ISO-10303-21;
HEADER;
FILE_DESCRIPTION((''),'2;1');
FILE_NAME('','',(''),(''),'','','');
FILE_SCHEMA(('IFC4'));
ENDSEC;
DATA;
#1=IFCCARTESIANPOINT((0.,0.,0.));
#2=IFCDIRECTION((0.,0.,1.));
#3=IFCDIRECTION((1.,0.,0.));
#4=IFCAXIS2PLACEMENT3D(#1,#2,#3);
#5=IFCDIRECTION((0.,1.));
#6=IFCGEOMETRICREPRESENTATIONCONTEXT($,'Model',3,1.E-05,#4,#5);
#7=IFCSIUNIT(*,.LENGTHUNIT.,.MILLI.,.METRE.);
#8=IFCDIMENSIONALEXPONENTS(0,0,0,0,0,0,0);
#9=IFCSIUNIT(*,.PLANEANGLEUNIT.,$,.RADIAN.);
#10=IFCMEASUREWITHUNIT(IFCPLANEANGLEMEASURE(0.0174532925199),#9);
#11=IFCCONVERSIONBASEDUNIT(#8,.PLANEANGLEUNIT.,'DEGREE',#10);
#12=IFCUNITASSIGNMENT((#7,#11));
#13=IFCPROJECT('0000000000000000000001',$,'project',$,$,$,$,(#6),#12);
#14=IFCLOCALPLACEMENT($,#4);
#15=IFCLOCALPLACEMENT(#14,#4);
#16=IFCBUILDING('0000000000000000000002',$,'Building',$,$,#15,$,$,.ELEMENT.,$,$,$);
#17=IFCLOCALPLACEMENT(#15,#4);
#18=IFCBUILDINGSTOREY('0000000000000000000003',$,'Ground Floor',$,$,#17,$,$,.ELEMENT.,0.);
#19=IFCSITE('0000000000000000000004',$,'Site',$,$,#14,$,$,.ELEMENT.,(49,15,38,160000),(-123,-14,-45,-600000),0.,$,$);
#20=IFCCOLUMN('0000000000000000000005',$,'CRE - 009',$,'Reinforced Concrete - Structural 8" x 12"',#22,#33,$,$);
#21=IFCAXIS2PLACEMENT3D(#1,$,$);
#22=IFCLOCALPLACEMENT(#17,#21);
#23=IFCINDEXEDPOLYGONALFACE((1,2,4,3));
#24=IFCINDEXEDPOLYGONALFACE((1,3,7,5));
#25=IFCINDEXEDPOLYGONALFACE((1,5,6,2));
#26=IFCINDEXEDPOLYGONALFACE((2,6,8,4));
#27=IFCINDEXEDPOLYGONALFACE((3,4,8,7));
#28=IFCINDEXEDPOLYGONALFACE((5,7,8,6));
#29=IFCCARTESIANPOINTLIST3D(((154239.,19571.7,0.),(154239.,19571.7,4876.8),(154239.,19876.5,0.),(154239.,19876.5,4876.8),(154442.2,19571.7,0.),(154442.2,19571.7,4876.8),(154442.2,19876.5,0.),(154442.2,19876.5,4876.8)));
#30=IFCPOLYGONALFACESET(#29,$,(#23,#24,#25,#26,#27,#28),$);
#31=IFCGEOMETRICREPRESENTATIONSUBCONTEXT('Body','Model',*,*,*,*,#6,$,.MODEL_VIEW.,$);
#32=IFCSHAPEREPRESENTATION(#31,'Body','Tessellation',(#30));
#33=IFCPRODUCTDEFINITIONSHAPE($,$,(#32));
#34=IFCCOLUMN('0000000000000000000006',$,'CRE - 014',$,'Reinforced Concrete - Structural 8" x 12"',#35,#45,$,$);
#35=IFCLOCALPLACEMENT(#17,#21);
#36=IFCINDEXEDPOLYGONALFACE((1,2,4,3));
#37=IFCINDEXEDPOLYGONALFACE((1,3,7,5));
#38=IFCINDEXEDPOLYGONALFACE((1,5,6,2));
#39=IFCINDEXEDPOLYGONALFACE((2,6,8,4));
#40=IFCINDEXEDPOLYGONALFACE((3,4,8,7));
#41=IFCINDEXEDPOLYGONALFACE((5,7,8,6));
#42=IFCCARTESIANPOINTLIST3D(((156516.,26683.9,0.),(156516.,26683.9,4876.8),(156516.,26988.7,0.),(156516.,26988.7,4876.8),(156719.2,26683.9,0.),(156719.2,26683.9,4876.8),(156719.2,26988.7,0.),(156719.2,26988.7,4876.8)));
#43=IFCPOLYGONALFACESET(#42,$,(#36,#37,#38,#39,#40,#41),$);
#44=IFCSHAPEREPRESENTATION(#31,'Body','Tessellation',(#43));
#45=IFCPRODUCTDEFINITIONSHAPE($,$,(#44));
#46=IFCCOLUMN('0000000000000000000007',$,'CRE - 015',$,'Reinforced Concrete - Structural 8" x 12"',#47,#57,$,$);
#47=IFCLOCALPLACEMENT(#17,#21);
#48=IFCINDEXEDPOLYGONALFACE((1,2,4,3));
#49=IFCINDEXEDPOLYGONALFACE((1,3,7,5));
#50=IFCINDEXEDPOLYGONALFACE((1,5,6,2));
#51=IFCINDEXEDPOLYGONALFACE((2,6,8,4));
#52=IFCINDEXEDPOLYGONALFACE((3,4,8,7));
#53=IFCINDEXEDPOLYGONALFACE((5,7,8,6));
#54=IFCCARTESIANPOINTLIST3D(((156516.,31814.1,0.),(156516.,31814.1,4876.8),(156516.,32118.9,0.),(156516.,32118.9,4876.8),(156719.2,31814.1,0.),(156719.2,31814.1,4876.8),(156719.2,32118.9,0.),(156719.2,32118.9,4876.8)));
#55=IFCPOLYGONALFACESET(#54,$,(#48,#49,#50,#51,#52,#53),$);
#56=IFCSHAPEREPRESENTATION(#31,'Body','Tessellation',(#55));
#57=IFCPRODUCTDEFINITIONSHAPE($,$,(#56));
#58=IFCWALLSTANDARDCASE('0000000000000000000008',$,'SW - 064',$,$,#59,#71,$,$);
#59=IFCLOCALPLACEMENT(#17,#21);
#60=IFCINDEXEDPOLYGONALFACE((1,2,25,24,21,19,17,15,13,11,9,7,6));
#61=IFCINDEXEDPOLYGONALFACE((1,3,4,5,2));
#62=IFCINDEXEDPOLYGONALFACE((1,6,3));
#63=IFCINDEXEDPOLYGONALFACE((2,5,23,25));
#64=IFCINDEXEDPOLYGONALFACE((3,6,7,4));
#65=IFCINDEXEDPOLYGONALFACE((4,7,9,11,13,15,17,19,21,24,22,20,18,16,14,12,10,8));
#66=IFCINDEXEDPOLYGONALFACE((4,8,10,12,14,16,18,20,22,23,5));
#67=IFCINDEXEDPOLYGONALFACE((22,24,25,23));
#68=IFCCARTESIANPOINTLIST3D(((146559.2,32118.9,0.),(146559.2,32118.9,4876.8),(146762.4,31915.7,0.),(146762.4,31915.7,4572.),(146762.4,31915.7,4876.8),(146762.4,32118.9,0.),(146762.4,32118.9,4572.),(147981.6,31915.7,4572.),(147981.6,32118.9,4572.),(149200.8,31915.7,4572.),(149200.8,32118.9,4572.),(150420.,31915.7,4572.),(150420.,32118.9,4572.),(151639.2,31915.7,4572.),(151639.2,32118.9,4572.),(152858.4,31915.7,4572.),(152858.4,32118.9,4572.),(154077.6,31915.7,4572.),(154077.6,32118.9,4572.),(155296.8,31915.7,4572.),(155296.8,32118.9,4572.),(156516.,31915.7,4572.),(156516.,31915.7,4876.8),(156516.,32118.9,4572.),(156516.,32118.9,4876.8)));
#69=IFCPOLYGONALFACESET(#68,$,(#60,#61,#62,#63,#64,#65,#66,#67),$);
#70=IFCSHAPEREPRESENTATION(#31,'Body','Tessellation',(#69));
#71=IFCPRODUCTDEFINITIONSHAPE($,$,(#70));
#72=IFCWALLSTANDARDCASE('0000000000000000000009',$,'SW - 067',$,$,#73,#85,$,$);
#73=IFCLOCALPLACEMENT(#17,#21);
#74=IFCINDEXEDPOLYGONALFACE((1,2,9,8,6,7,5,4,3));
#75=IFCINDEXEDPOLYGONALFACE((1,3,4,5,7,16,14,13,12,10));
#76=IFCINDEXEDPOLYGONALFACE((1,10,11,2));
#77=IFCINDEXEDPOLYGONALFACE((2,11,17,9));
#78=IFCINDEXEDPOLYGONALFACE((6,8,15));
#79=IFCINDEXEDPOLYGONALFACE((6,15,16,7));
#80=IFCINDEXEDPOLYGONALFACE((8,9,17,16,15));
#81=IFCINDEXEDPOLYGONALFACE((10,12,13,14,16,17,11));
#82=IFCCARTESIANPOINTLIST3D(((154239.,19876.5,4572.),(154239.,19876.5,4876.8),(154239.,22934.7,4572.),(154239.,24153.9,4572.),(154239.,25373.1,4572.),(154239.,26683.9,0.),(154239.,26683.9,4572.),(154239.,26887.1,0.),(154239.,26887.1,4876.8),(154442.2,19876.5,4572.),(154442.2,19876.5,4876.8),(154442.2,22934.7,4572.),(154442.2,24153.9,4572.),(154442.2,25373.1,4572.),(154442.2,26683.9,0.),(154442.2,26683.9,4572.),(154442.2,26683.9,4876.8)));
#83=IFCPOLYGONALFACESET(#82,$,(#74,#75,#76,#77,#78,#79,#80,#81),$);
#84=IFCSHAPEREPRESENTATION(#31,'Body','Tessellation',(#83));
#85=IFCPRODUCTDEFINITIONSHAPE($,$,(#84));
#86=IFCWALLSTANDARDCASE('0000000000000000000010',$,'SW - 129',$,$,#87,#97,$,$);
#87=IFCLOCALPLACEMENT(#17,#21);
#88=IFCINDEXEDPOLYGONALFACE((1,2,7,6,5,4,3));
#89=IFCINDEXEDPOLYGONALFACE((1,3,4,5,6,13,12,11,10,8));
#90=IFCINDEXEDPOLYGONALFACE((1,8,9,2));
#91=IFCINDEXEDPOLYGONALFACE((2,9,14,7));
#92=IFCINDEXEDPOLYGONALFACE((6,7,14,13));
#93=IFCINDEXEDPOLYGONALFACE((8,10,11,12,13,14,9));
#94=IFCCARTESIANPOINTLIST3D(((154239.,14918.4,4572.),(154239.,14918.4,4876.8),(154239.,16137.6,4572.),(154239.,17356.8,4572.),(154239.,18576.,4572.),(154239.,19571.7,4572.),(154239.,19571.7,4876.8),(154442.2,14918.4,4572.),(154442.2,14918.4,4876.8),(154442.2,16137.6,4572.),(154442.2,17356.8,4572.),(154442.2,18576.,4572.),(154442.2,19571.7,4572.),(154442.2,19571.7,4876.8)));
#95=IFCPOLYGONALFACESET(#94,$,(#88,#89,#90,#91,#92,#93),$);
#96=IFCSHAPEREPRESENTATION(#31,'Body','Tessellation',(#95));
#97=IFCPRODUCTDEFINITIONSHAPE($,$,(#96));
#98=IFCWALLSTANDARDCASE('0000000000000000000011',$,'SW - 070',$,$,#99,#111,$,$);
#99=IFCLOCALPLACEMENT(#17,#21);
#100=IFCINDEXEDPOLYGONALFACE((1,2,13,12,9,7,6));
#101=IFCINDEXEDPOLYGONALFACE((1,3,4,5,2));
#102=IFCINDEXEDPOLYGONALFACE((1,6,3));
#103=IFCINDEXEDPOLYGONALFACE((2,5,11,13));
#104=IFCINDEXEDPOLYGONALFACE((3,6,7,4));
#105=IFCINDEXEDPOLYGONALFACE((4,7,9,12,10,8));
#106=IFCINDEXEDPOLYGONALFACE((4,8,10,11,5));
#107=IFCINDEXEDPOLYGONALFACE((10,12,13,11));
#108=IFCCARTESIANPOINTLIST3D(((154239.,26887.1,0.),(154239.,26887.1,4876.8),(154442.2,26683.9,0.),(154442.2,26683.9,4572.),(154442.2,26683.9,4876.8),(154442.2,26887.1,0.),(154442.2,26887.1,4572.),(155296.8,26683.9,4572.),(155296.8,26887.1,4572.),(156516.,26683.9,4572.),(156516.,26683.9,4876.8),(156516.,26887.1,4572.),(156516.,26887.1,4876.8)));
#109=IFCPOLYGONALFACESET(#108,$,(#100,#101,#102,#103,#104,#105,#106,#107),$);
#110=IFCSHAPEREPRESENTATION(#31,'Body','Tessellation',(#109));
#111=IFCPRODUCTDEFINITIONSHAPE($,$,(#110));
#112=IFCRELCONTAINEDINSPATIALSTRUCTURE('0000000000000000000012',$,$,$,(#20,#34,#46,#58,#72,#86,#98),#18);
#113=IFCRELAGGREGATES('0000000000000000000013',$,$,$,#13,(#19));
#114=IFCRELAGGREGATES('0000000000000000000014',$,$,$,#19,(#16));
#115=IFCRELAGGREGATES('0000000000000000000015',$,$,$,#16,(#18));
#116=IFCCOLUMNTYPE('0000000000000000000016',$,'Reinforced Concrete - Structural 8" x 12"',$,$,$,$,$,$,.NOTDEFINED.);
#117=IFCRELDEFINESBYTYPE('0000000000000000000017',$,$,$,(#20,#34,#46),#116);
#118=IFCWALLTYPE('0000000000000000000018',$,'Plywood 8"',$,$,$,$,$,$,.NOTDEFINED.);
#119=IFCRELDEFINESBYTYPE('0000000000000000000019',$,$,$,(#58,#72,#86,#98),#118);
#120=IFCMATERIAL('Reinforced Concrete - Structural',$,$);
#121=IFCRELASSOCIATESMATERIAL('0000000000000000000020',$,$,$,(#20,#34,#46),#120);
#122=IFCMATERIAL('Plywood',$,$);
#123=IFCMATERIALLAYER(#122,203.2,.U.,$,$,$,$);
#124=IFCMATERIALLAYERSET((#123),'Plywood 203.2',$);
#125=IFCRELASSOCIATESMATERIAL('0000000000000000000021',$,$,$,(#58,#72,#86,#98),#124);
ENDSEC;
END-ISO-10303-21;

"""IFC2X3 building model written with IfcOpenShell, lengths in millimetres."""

from ifc_helpers import new_model, entity, si_unit, converted_unit, direction, frame, origin_with_axes, origin_2d_with_axis, place, context, subcontext, project, spatial, polyline, rectangle, outline, extrude, material, layer, layer_set, layer_usage, type_object, element, save


model = new_model("IFC2X3")

# Units and contexts
model_context = context("Model", 3, precision=1e-05, world=origin_with_axes(), true_north=direction((0.0, 1.0)))
body_context = subcontext(model_context, "Body", "Model", "MODEL_VIEW")
ifc_project = project(units=[si_unit("LENGTHUNIT", "METRE", prefix="MILLI"), converted_unit("PLANEANGLEUNIT", "DEGREE", entity("IfcPlaneAngleMeasure", 0.0174532925199), si_unit("PLANEANGLEUNIT", "RADIAN"), dimensions=[0, 0, 0, 0, 0, 0, 0])], contexts=[model_context])

# Site, building, storey
site_placement = place(None, origin_with_axes())
site = spatial("IfcSite", under=ifc_project, at=site_placement, Name="Site", CompositionType="ELEMENT", RefLatitude=(49, 15, 38, 160000), RefLongitude=(-123, -14, -45, -600000), RefElevation=0.0)
building_placement = place(site_placement, origin_with_axes())
building = spatial("IfcBuilding", under=site, at=building_placement, Name="Building", CompositionType="ELEMENT")
storey_placement = place(building_placement, origin_with_axes())
storey = spatial("IfcBuildingStorey", under=building, at=storey_placement, Name="Ground Floor", CompositionType="ELEMENT", Elevation=0.0)

# Columns
ifc_material_1 = material(Name="Reinforced Concrete - Structural")
column_type = type_object("IfcColumnType", Name="Reinforced Concrete - Structural 8\" x 12\"", PredefinedType="NOTDEFINED")
for number, where, z_axis, x_axis, name in (
    (1, (154340.6, 19724.1, 0.0), (0.0, 0.0, 1.0), (1.0, 0.0, 0.0), "CRE - 009"),
    (2, (156617.6, 26836.3, 0.0), (0.0, 0.0, 1.0), (1.0, 0.0, 0.0), "CRE - 014"),
    (3, (156617.6, 31966.5, 0.0), (0.0, 0.0, 1.0), (1.0, 0.0, 0.0), "CRE - 015"),
):
    element("IfcColumn", number, at=place(storey_placement, frame(where, z_axis=z_axis, x_axis=x_axis)), inside=storey, type_object=column_type, material=ifc_material_1, Name=name, ObjectType="Reinforced Concrete - Structural 8\" x 12\"", context=body_context, shape_type="SweptSolid", body=[
        extrude(rectangle(XDim=203.2, YDim=304.8, at=origin_2d_with_axis()), origin_with_axes(), (0.0, 0.0, 1.0), 4876.8),
    ])

# Walls, openings
ifc_material_2 = material(Name="Plywood")
ifc_layer = layer(ifc_material_2, 203.2, ventilated="UNKNOWN")
ifc_layer_set = layer_set([ifc_layer], Name="Plywood 203.2")
ifc_layer_usage_1 = layer_usage(ifc_layer_set, "AXIS2", "NEGATIVE", 0.0)
wall_type = type_object("IfcWallType", Name="Plywood 8\"", PredefinedType="NOTDEFINED")
wall_1_placement = place(storey_placement, frame((156516.0, 31915.7, 0.0), z_axis=(0.0, 0.0, 1.0), x_axis=(-1.0, 0.0, 0.0)))
wall_1 = element("IfcWallStandardCase", 4, at=wall_1_placement, inside=storey, type_object=wall_type, material=ifc_layer_usage_1, Name="SW - 064", context=body_context, shape_type="SweptSolid", body=[
    extrude(outline(polyline([(0.0, -203.2), (9956.8, -203.2), (9753.6, 0.0), (0.0, 0.0), (0.0, -203.2)])), origin_with_axes(), (0.0, 0.0, 1.0), 4876.8),
])
opening_1_placement = place(wall_1_placement, frame((9144.0, 0.0, 0.0), z_axis=(0.0, 0.0, 1.0), x_axis=(1.0, 0.0, 0.0)))
element("IfcOpeningElement", 5, at=opening_1_placement, cuts=wall_1, context=body_context, shape_type="SweptSolid", body=[
    extrude(rectangle(XDim=1219.2, YDim=4572.0, at=origin_2d_with_axis()), frame((0.0, 203.2, 2286.0), z_axis=(0.0, -1.0, 0.0), x_axis=(-1.0, 0.0, 0.0)), (0.0, 0.0, 1.0), 609.6),
])
opening_2_placement = place(wall_1_placement, frame((609.6, 0.0, 0.0), z_axis=(0.0, 0.0, 1.0), x_axis=(1.0, 0.0, 0.0)))
element("IfcOpeningElement", 6, at=opening_2_placement, cuts=wall_1, context=body_context, shape_type="SweptSolid", body=[
    extrude(rectangle(XDim=1219.2, YDim=4572.0, at=origin_2d_with_axis()), frame((0.0, 203.2, 2286.0), z_axis=(0.0, -1.0, 0.0), x_axis=(-1.0, 0.0, 0.0)), (0.0, 0.0, 1.0), 609.6),
])
opening_3_placement = place(wall_1_placement, frame((1828.8, 0.0, 0.0), z_axis=(0.0, 0.0, 1.0), x_axis=(1.0, 0.0, 0.0)))
element("IfcOpeningElement", 7, at=opening_3_placement, cuts=wall_1, context=body_context, shape_type="SweptSolid", body=[
    extrude(rectangle(XDim=1219.2, YDim=4572.0, at=origin_2d_with_axis()), frame((0.0, 203.2, 2286.0), z_axis=(0.0, 1.0, 0.0), x_axis=(1.0, 0.0, 0.0)), (0.0, 0.0, -1.0), 609.6),
])
opening_4_placement = place(wall_1_placement, frame((3048.0, 0.0, 0.0), z_axis=(0.0, 0.0, 1.0), x_axis=(1.0, 0.0, 0.0)))
element("IfcOpeningElement", 8, at=opening_4_placement, cuts=wall_1, context=body_context, shape_type="SweptSolid", body=[
    extrude(rectangle(XDim=1219.2, YDim=4572.0, at=origin_2d_with_axis()), frame((0.0, 203.2, 2286.0), z_axis=(0.0, 1.0, 0.0), x_axis=(1.0, 0.0, 0.0)), (0.0, 0.0, -1.0), 609.6),
])
opening_5_placement = place(wall_1_placement, frame((4267.2, 0.0, 0.0), z_axis=(0.0, 0.0, 1.0), x_axis=(1.0, 0.0, 0.0)))
element("IfcOpeningElement", 9, at=opening_5_placement, cuts=wall_1, context=body_context, shape_type="SweptSolid", body=[
    extrude(rectangle(XDim=1219.2, YDim=4572.0, at=origin_2d_with_axis()), frame((0.0, 203.2, 2286.0), z_axis=(0.0, -1.0, 0.0), x_axis=(-1.0, 0.0, 0.0)), (0.0, 0.0, 1.0), 609.6),
])
opening_6_placement = place(wall_1_placement, frame((5486.4, 0.0, 0.0), z_axis=(0.0, 0.0, 1.0), x_axis=(1.0, 0.0, 0.0)))
element("IfcOpeningElement", 10, at=opening_6_placement, cuts=wall_1, context=body_context, shape_type="SweptSolid", body=[
    extrude(rectangle(XDim=1219.2, YDim=4572.0, at=origin_2d_with_axis()), frame((0.0, 203.2, 2286.0), z_axis=(0.0, 1.0, 0.0), x_axis=(1.0, 0.0, 0.0)), (0.0, 0.0, -1.0), 609.6),
])
opening_7_placement = place(wall_1_placement, frame((6705.6, 0.0, 0.0), z_axis=(0.0, 0.0, 1.0), x_axis=(1.0, 0.0, 0.0)))
element("IfcOpeningElement", 11, at=opening_7_placement, cuts=wall_1, context=body_context, shape_type="SweptSolid", body=[
    extrude(rectangle(XDim=1219.2, YDim=4572.0, at=origin_2d_with_axis()), frame((0.0, 203.2, 2286.0), z_axis=(0.0, -1.0, 0.0), x_axis=(-1.0, 0.0, 0.0)), (0.0, 0.0, 1.0), 609.6),
])
opening_8_placement = place(wall_1_placement, frame((7924.8, 0.0, 0.0), z_axis=(0.0, 0.0, 1.0), x_axis=(1.0, 0.0, 0.0)))
element("IfcOpeningElement", 12, at=opening_8_placement, cuts=wall_1, context=body_context, shape_type="SweptSolid", body=[
    extrude(rectangle(XDim=1219.2, YDim=4572.0, at=origin_2d_with_axis()), frame((0.0, 203.2, 2286.0), z_axis=(0.0, 1.0, 0.0), x_axis=(1.0, 0.0, 0.0)), (0.0, 0.0, -1.0), 609.6),
])
ifc_layer_usage_2 = layer_usage(ifc_layer_set, "AXIS2", "POSITIVE", 0.0)
wall_2_placement = place(storey_placement, frame((154239.0, 26887.1, 0.0), z_axis=(0.0, 0.0, 1.0), x_axis=(0.0, -1.0, 0.0)))
wall_2 = element("IfcWallStandardCase", 13, at=wall_2_placement, inside=storey, type_object=wall_type, material=ifc_layer_usage_2, Name="SW - 067", context=body_context, shape_type="SweptSolid", body=[
    extrude(outline(polyline([(0.0, 0.0), (7010.6, 0.0), (7010.6, 203.2), (203.2, 203.2), (0.0, 0.0)])), origin_with_axes(), (0.0, 0.0, 1.0), 4876.8),
])
opening_9_placement = place(wall_2_placement, frame((858.6, 0.0, 0.0), z_axis=(0.0, 0.0, 1.0), x_axis=(1.0, 0.0, 0.0)))
element("IfcOpeningElement", 14, at=opening_9_placement, cuts=wall_2, context=body_context, shape_type="SweptSolid", body=[
    extrude(rectangle(XDim=1310.8, YDim=4572.0, at=origin_2d_with_axis()), frame((0.0, -203.2, 2286.0), z_axis=(0.0, -1.0, 0.0), x_axis=(-1.0, 0.0, 0.0)), (0.0, 0.0, -1.0), 609.6),
])
opening_10_placement = place(wall_2_placement, frame((2123.6, 0.0, 0.0), z_axis=(0.0, 0.0, 1.0), x_axis=(1.0, 0.0, 0.0)))
element("IfcOpeningElement", 15, at=opening_10_placement, cuts=wall_2, context=body_context, shape_type="SweptSolid", body=[
    extrude(rectangle(XDim=1219.2, YDim=4572.0, at=origin_2d_with_axis()), frame((0.0, -203.2, 2286.0), z_axis=(0.0, 1.0, 0.0), x_axis=(1.0, 0.0, 0.0)), (0.0, 0.0, 1.0), 609.6),
])
opening_11_placement = place(wall_2_placement, frame((3342.8, 0.0, 0.0), z_axis=(0.0, 0.0, 1.0), x_axis=(1.0, 0.0, 0.0)))
element("IfcOpeningElement", 16, at=opening_11_placement, cuts=wall_2, context=body_context, shape_type="SweptSolid", body=[
    extrude(rectangle(XDim=1219.2, YDim=4572.0, at=origin_2d_with_axis()), frame((0.0, -203.2, 2286.0), z_axis=(0.0, -1.0, 0.0), x_axis=(-1.0, 0.0, 0.0)), (0.0, 0.0, -1.0), 609.6),
])
opening_12_placement = place(wall_2_placement, frame((5481.5, 0.0, 0.0), z_axis=(0.0, 0.0, 1.0), x_axis=(1.0, 0.0, 0.0)))
element("IfcOpeningElement", 17, at=opening_12_placement, cuts=wall_2, context=body_context, shape_type="SweptSolid", body=[
    extrude(rectangle(XDim=3058.2, YDim=4572.0, at=origin_2d_with_axis()), frame((0.0, -203.2, 2286.0), z_axis=(0.0, -1.0, 0.0), x_axis=(-1.0, 0.0, 0.0)), (0.0, 0.0, -1.0), 609.6),
])
ifc_layer_usage_3 = layer_usage(ifc_layer_set, "AXIS2", "POSITIVE", 0.0)
wall_3_placement = place(storey_placement, frame((154239.0, 19571.7, 0.0), z_axis=(0.0, 0.0, 1.0), x_axis=(0.0, -1.0, 0.0)))
wall_3 = element("IfcWallStandardCase", 18, at=wall_3_placement, inside=storey, type_object=wall_type, material=ifc_layer_usage_3, Name="SW - 129", context=body_context, shape_type="SweptSolid", body=[
    extrude(outline(polyline([(0.0, 0.0), (4653.2, 0.0), (4653.2, 203.2), (0.0, 203.2), (0.0, 0.0)])), origin_with_axes(), (0.0, 0.0, 1.0), 4876.8),
])
opening_13_placement = place(wall_3_placement, frame((497.8, 0.0, 0.0), z_axis=(0.0, 0.0, 1.0), x_axis=(1.0, 0.0, 0.0)))
element("IfcOpeningElement", 19, at=opening_13_placement, cuts=wall_3, context=body_context, shape_type="SweptSolid", body=[
    extrude(rectangle(XDim=995.6, YDim=4572.0, at=origin_2d_with_axis()), frame((0.0, -203.2, 2286.0), z_axis=(0.0, 1.0, 0.0), x_axis=(1.0, 0.0, 0.0)), (0.0, 0.0, 1.0), 609.6),
])
opening_14_placement = place(wall_3_placement, frame((1605.2, 0.0, 0.0), z_axis=(0.0, 0.0, 1.0), x_axis=(1.0, 0.0, 0.0)))
element("IfcOpeningElement", 20, at=opening_14_placement, cuts=wall_3, context=body_context, shape_type="SweptSolid", body=[
    extrude(rectangle(XDim=1219.2, YDim=4572.0, at=origin_2d_with_axis()), frame((0.0, -203.2, 2286.0), z_axis=(0.0, 1.0, 0.0), x_axis=(1.0, 0.0, 0.0)), (0.0, 0.0, 1.0), 609.6),
])
opening_15_placement = place(wall_3_placement, frame((2824.4, 0.0, 0.0), z_axis=(0.0, 0.0, 1.0), x_axis=(1.0, 0.0, 0.0)))
element("IfcOpeningElement", 21, at=opening_15_placement, cuts=wall_3, context=body_context, shape_type="SweptSolid", body=[
    extrude(rectangle(XDim=1219.2, YDim=4572.0, at=origin_2d_with_axis()), frame((0.0, -203.2, 2286.0), z_axis=(0.0, -1.0, 0.0), x_axis=(-1.0, 0.0, 0.0)), (0.0, 0.0, -1.0), 609.6),
])
opening_16_placement = place(wall_3_placement, frame((4043.6, 0.0, 0.0), z_axis=(0.0, 0.0, 1.0), x_axis=(1.0, 0.0, 0.0)))
element("IfcOpeningElement", 22, at=opening_16_placement, cuts=wall_3, context=body_context, shape_type="SweptSolid", body=[
    extrude(rectangle(XDim=1219.2, YDim=4572.0, at=origin_2d_with_axis()), frame((0.0, -203.2, 2286.0), z_axis=(0.0, -1.0, 0.0), x_axis=(-1.0, 0.0, 0.0)), (0.0, 0.0, -1.0), 609.6),
])
ifc_layer_usage_4 = layer_usage(ifc_layer_set, "AXIS2", "NEGATIVE", 0.0)
wall_4_placement = place(storey_placement, frame((154239.0, 26887.1, 0.0), z_axis=(0.0, 0.0, 1.0), x_axis=(1.0, 0.0, 0.0)))
wall_4 = element("IfcWallStandardCase", 23, at=wall_4_placement, inside=storey, type_object=wall_type, material=ifc_layer_usage_4, Name="SW - 070", context=body_context, shape_type="SweptSolid", body=[
    extrude(outline(polyline([(203.2, -203.2), (2277.0, -203.2), (2277.0, 0.0), (0.0, 0.0), (203.2, -203.2)])), origin_with_axes(), (0.0, 0.0, 1.0), 4876.8),
])
opening_17_placement = place(wall_4_placement, frame((630.5, 0.0, 0.0), z_axis=(0.0, 0.0, 1.0), x_axis=(1.0, 0.0, 0.0)))
element("IfcOpeningElement", 24, at=opening_17_placement, cuts=wall_4, context=body_context, shape_type="SweptSolid", body=[
    extrude(rectangle(XDim=854.6, YDim=4572.0, at=origin_2d_with_axis()), frame((0.0, 203.2, 2286.0), z_axis=(0.0, 1.0, 0.0), x_axis=(1.0, 0.0, 0.0)), (0.0, 0.0, -1.0), 609.6),
])
opening_18_placement = place(wall_4_placement, frame((1667.4, 0.0, 0.0), z_axis=(0.0, 0.0, 1.0), x_axis=(1.0, 0.0, 0.0)))
element("IfcOpeningElement", 25, at=opening_18_placement, cuts=wall_4, context=body_context, shape_type="SweptSolid", body=[
    extrude(rectangle(XDim=1219.2, YDim=4572.0, at=origin_2d_with_axis()), frame((0.0, 203.2, 2286.0), z_axis=(0.0, 1.0, 0.0), x_axis=(1.0, 0.0, 0.0)), (0.0, 0.0, -1.0), 609.6),
])

save(model, "model.ifc")
